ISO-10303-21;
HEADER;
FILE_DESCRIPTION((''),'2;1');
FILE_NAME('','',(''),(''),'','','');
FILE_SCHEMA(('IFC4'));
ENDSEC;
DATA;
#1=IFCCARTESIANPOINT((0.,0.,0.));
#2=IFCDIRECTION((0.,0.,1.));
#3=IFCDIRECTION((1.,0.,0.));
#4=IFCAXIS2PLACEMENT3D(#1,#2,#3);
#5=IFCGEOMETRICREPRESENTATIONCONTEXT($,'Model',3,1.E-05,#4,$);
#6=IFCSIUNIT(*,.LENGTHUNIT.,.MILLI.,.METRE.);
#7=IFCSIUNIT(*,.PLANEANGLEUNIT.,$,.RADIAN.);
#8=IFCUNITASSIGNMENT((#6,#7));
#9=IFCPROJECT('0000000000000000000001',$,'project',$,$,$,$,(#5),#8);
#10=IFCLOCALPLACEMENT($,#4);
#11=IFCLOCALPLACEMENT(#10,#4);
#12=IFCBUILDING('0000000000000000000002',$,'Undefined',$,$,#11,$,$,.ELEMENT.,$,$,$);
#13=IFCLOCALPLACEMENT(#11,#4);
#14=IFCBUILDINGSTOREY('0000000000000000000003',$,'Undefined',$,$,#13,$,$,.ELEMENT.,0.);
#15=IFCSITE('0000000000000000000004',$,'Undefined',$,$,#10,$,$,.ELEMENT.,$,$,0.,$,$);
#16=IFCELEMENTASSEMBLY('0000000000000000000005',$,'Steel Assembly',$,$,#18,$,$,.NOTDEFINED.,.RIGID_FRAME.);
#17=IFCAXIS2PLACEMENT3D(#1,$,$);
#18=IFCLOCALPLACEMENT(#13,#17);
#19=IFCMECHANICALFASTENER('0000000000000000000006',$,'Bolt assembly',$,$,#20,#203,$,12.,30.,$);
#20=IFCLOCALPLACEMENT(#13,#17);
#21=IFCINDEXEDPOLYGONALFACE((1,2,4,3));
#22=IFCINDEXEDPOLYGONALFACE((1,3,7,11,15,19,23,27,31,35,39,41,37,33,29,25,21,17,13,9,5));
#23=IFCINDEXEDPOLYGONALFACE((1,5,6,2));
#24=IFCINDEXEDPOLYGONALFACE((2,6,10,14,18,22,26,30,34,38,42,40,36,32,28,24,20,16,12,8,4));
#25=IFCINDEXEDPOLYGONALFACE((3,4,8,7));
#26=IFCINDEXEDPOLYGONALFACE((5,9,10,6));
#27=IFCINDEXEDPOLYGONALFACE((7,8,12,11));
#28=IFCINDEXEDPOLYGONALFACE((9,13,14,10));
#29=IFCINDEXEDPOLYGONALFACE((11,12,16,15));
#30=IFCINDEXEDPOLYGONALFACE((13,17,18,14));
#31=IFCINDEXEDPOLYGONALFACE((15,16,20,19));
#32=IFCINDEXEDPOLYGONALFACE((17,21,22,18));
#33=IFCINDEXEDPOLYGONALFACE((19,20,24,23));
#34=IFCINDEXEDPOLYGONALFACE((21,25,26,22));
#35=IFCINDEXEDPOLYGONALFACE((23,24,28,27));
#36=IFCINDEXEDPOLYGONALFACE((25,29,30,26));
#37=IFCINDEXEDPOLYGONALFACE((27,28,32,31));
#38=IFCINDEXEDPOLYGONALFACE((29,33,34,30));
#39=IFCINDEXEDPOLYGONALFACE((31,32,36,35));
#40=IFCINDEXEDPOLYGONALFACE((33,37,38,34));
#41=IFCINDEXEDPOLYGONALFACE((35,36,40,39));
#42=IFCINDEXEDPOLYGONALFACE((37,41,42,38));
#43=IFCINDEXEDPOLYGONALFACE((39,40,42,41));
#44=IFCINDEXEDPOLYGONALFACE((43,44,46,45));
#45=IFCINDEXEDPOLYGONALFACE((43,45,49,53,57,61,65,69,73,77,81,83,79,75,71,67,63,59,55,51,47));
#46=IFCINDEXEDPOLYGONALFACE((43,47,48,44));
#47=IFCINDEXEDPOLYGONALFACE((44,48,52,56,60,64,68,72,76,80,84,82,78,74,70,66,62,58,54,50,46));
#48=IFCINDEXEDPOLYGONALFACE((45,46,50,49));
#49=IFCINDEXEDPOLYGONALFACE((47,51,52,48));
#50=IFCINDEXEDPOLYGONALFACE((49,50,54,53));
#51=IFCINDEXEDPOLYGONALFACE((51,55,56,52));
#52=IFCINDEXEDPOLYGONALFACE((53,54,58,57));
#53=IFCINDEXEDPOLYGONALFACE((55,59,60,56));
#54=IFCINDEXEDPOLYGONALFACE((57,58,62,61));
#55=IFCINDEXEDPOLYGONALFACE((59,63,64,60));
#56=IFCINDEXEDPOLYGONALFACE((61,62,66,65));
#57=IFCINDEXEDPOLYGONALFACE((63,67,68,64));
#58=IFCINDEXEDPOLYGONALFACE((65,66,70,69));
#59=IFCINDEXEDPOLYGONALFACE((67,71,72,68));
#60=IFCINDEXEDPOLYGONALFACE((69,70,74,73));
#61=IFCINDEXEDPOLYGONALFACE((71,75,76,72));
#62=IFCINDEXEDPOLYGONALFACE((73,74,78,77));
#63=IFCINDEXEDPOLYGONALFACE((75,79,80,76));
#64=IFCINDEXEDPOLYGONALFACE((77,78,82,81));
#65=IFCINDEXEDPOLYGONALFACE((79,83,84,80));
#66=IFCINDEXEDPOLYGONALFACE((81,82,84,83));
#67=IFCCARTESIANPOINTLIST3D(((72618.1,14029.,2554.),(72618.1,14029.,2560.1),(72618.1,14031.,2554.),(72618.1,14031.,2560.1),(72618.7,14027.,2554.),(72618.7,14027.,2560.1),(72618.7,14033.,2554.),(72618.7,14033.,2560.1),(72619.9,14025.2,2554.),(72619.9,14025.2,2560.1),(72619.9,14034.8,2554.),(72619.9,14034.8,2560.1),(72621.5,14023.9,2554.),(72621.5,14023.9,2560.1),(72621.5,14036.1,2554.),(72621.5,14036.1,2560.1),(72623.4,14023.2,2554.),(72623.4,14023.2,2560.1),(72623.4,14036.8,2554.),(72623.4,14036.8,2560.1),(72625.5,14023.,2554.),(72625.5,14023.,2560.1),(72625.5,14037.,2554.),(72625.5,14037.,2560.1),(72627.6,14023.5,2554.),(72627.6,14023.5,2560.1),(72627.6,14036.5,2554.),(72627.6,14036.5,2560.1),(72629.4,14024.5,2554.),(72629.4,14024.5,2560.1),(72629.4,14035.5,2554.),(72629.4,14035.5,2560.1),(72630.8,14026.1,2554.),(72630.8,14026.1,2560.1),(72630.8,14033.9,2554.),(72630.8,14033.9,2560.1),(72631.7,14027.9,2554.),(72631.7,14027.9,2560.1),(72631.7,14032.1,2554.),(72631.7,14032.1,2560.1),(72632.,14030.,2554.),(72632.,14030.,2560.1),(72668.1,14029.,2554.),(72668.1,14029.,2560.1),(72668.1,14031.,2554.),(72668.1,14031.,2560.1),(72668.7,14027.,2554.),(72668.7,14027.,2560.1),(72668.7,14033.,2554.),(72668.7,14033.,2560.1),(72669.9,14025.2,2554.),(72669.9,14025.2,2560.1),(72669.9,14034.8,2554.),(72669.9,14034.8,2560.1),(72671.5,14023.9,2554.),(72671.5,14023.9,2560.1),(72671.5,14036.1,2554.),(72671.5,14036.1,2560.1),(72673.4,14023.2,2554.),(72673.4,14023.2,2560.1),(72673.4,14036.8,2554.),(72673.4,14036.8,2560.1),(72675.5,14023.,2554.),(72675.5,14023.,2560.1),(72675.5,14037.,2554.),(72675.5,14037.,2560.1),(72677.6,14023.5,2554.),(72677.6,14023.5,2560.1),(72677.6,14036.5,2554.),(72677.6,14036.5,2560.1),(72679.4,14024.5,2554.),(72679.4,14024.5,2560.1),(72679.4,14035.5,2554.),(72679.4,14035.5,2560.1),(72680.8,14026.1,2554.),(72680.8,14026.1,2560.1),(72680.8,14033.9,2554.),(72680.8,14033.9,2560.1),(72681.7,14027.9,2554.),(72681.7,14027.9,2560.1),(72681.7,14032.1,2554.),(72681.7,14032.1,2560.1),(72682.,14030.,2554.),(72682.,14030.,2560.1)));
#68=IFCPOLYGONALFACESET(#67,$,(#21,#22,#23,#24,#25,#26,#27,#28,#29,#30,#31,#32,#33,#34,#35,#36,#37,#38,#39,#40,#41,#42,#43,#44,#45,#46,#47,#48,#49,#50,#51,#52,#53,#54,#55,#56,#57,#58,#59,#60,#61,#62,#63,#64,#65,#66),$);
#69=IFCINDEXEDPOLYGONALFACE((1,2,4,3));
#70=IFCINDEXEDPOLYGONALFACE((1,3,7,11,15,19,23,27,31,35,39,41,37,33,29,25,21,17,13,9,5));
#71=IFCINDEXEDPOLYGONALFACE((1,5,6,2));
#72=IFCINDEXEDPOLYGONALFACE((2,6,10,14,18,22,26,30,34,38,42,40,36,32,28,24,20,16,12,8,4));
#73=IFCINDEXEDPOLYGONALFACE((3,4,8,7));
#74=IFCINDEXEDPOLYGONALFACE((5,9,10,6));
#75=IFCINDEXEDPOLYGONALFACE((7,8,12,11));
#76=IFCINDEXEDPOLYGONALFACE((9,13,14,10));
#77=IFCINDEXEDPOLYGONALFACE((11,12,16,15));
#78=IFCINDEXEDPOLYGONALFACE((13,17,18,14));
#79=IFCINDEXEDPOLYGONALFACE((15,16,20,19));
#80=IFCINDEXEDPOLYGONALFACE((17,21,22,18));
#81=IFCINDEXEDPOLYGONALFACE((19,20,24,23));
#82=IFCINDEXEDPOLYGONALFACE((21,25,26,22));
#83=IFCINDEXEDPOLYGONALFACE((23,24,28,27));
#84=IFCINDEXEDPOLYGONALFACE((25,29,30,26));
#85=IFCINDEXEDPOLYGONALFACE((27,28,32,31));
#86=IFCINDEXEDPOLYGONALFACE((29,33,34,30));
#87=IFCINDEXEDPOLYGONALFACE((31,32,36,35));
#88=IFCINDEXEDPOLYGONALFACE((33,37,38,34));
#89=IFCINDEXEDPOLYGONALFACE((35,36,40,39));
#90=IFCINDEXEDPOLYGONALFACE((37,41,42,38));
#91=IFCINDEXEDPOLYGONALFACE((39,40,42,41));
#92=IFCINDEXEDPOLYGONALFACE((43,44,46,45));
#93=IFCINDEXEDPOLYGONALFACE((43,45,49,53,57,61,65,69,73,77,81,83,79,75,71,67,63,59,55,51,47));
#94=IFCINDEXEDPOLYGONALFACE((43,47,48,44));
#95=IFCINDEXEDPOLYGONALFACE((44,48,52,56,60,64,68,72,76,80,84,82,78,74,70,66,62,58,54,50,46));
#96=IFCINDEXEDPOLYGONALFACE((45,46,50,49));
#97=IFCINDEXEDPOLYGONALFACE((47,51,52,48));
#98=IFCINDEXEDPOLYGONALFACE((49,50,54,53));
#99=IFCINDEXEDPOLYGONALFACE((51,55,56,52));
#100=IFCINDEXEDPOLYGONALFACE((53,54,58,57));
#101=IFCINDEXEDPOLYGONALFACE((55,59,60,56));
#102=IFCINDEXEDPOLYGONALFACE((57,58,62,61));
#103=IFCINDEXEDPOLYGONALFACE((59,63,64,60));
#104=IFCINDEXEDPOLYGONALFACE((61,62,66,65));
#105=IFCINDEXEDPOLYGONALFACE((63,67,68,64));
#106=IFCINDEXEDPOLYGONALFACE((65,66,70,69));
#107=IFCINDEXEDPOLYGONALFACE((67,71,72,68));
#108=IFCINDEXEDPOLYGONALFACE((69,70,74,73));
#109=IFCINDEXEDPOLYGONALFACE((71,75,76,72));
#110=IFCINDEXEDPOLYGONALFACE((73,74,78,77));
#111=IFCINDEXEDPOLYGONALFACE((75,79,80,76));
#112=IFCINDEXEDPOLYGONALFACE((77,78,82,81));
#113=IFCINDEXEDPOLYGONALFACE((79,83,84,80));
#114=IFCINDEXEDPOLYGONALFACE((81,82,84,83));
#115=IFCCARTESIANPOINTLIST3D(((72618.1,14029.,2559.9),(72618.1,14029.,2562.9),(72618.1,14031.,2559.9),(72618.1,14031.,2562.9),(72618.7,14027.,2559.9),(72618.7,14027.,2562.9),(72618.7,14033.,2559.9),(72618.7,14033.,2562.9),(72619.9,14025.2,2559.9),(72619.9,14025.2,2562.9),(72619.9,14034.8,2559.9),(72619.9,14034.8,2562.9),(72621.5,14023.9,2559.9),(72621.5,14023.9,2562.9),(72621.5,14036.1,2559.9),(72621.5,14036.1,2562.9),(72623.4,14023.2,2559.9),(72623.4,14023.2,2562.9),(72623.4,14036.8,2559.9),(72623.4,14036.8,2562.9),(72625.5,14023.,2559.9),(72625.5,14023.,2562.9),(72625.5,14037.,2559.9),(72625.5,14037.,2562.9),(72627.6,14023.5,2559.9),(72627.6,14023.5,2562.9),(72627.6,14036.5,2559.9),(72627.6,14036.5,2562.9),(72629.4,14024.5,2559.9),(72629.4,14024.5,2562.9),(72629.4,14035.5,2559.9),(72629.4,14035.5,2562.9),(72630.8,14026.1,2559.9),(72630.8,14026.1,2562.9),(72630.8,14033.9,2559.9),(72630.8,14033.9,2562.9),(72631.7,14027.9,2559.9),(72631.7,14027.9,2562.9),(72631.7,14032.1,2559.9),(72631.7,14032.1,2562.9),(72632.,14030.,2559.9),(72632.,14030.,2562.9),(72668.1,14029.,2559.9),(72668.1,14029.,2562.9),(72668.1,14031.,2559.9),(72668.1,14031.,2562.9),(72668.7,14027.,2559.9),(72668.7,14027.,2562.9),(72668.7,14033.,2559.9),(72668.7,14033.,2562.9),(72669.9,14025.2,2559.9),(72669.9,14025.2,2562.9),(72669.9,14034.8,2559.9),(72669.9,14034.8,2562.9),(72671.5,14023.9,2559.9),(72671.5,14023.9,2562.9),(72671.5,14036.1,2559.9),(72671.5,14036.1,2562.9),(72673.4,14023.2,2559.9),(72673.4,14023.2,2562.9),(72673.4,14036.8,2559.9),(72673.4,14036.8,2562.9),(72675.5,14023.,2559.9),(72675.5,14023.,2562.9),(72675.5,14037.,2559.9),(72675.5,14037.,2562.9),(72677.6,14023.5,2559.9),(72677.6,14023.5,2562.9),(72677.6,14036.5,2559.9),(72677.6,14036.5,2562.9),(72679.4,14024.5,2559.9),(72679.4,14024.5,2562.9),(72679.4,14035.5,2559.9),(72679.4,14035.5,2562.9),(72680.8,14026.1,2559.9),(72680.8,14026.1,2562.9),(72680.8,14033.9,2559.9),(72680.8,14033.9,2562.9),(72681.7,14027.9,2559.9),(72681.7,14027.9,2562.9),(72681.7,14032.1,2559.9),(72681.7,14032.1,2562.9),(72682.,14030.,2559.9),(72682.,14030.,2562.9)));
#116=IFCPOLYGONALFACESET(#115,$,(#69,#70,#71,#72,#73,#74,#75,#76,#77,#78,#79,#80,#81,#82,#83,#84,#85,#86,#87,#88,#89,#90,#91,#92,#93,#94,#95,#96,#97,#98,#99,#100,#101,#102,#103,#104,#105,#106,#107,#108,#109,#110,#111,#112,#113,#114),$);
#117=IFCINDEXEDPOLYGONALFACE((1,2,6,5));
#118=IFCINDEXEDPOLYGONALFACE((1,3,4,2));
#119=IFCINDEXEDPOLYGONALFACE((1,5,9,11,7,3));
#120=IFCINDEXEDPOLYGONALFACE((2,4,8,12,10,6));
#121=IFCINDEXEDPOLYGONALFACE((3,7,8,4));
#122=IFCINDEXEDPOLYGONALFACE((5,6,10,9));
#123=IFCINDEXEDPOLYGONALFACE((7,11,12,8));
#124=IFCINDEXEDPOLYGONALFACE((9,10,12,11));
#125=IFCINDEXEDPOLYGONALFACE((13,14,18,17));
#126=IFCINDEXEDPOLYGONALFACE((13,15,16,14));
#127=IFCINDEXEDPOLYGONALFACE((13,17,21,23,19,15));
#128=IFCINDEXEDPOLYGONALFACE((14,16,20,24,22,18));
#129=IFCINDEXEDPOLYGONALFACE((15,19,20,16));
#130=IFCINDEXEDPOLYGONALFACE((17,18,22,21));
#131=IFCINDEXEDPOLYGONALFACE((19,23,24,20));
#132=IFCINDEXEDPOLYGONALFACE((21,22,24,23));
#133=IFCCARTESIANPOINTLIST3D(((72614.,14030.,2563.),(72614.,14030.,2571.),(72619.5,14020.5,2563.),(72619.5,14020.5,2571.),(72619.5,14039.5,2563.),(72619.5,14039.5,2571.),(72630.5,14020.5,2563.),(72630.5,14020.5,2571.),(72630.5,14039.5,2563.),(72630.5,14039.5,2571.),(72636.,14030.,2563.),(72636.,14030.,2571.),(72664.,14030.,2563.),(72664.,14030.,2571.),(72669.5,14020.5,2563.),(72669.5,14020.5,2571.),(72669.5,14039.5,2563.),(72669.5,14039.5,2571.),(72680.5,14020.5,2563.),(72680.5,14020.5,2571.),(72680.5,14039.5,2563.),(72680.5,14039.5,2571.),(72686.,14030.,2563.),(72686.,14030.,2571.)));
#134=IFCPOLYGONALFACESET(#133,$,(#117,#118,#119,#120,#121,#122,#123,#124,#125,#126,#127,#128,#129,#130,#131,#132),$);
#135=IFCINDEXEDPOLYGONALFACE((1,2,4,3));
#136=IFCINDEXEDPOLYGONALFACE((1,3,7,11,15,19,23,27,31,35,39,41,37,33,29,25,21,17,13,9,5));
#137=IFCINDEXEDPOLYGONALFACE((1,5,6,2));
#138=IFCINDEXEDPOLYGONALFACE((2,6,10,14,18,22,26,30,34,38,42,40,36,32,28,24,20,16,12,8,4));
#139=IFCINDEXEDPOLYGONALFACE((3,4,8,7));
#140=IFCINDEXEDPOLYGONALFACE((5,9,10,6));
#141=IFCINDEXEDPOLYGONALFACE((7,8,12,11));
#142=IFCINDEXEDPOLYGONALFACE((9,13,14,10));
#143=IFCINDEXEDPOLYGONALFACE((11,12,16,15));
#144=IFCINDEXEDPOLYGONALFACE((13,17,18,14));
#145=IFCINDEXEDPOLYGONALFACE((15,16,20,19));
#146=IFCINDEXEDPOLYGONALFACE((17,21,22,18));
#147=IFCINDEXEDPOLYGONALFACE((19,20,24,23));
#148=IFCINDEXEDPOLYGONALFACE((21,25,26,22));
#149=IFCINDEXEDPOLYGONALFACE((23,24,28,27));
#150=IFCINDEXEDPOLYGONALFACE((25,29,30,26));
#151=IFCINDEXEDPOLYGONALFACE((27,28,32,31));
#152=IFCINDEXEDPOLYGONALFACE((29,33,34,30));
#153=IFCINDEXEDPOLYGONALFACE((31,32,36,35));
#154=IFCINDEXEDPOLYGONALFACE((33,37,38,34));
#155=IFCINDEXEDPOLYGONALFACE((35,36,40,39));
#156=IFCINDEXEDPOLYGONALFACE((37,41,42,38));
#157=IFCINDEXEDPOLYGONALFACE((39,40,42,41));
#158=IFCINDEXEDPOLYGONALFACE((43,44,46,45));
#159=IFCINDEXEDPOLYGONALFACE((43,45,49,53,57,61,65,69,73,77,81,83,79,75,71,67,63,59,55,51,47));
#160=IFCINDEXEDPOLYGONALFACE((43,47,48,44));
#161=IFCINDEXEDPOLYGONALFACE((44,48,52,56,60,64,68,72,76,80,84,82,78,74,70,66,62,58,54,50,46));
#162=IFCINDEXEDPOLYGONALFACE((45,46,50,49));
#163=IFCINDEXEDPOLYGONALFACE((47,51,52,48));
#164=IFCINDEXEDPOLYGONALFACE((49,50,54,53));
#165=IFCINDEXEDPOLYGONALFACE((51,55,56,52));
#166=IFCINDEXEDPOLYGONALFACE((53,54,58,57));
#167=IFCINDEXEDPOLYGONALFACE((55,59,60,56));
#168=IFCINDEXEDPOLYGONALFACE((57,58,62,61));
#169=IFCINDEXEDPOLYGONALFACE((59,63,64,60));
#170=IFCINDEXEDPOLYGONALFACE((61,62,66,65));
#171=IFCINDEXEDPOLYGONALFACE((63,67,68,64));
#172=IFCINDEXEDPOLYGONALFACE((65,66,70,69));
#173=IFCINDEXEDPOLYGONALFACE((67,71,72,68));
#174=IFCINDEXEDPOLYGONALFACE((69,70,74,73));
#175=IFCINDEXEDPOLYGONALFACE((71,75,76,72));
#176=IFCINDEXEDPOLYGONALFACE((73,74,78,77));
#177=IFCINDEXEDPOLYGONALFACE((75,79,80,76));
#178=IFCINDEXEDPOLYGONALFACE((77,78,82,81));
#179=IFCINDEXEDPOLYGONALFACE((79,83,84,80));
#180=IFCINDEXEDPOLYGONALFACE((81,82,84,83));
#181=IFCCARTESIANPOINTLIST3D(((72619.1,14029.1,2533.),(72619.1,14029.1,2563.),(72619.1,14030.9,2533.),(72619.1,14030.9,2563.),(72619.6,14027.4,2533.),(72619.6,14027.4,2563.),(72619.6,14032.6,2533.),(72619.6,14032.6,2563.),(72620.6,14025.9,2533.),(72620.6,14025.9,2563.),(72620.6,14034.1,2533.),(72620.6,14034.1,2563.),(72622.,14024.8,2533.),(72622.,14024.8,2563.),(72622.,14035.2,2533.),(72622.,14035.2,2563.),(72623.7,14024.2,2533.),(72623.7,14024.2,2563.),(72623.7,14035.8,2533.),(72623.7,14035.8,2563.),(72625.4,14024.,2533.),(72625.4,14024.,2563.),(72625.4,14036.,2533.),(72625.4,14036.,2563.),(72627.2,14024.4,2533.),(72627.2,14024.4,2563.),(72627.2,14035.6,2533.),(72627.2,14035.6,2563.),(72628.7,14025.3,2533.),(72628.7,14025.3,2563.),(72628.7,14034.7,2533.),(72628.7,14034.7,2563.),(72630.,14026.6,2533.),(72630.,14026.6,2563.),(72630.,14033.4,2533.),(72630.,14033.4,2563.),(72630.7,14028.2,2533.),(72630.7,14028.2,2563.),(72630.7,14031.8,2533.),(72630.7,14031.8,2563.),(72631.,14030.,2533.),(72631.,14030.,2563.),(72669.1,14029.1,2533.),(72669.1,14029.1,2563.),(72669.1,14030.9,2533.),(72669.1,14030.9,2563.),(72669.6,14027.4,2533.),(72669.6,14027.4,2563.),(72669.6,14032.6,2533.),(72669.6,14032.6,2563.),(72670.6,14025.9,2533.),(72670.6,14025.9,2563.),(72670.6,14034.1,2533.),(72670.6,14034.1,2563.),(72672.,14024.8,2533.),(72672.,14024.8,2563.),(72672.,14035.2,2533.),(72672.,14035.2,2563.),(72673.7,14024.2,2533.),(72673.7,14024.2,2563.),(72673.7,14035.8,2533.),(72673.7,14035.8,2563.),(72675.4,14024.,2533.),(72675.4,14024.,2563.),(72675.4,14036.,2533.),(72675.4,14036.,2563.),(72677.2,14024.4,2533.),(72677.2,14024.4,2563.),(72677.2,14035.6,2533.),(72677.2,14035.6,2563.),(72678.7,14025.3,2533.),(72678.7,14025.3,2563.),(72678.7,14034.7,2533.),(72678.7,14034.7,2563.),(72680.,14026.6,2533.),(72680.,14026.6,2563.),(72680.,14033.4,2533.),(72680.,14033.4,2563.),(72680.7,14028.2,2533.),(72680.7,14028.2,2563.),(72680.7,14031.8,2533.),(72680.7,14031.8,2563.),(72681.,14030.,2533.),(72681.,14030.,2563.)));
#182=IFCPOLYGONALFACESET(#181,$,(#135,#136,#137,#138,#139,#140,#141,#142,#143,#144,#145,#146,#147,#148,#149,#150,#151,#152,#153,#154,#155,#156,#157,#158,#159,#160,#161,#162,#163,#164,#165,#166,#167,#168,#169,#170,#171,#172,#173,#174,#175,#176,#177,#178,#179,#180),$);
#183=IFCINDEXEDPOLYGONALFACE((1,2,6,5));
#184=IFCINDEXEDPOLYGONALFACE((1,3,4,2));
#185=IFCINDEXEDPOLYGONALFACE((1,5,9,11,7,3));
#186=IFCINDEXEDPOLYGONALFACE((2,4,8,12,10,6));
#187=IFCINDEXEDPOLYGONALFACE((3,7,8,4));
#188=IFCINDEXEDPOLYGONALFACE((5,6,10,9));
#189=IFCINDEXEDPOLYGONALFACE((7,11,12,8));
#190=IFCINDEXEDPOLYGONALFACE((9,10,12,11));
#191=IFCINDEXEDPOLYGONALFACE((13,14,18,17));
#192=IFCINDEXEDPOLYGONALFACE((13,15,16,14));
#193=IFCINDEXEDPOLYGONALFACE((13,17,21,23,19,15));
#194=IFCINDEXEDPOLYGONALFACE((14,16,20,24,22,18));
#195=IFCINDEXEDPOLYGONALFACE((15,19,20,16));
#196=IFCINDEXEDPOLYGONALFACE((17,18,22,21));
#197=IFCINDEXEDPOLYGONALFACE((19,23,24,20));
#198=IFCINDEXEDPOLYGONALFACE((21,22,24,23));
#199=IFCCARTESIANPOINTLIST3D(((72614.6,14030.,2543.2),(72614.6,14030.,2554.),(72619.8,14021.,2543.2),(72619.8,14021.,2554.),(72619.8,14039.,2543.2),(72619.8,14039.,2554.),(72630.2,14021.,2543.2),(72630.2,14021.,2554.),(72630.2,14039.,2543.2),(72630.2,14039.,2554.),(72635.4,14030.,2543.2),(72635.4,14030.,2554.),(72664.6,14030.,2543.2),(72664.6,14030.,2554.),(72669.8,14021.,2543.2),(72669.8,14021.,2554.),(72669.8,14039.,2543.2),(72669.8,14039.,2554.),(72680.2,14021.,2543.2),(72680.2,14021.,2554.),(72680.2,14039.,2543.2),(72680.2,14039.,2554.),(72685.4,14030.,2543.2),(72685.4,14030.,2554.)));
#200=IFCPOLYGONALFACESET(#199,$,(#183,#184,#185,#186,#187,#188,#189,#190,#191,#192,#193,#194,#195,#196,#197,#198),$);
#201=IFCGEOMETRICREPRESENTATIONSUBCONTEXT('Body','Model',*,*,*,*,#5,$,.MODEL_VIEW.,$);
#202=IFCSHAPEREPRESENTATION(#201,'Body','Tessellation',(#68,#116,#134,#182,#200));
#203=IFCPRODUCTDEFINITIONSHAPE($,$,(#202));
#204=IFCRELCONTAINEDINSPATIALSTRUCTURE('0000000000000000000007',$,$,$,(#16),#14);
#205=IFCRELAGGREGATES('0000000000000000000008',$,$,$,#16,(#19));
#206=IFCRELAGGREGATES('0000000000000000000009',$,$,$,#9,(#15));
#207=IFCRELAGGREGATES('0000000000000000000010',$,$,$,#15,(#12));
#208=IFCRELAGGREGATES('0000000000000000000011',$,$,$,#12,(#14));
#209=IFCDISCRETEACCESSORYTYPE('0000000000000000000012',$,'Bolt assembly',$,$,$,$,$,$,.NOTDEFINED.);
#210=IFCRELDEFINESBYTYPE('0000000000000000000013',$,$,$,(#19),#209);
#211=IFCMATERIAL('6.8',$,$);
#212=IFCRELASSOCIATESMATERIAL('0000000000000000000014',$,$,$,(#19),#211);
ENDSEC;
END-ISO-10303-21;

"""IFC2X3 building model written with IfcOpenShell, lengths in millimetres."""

from ifc_helpers import new_model, si_unit, frame, origin_with_axes, origin_2d_with_axis, place, context, subcontext, project, spatial, polyline, circle, outline, extrude, source, transform, mapped, material, type_object, element, aggregate, save


model = new_model("IFC2X3")

# Units and contexts
model_context = context("Model", 3, precision=1e-05, world=origin_with_axes())
body_context = subcontext(model_context, "Body", "Model", "MODEL_VIEW")
ifc_project = project(units=[si_unit("LENGTHUNIT", "METRE", prefix="MILLI"), si_unit("PLANEANGLEUNIT", "RADIAN")], contexts=[model_context])

# Site, building, storey
site_placement = place(None, origin_with_axes())
site = spatial("IfcSite", under=ifc_project, at=site_placement, Name="Undefined", CompositionType="ELEMENT", RefElevation=0.0)
building_placement = place(site_placement, origin_with_axes())
building = spatial("IfcBuilding", under=site, at=building_placement, Name="Undefined", CompositionType="ELEMENT")
storey_placement = place(building_placement, origin_with_axes())
storey = spatial("IfcBuildingStorey", under=building, at=storey_placement, Name="Undefined", CompositionType="ELEMENT", Elevation=0.0)

# Element assembly
assembly_1_placement = place(storey_placement, origin_with_axes())
assembly_1 = element("IfcElementAssembly", 1, at=assembly_1_placement, inside=storey, Name="Steel Assembly", AssemblyPlace="NOTDEFINED", PredefinedType="RIGID_FRAME")

# Shared definitions
ifc_material_1 = material(Name="6.8")
discrete_accessory_type_1 = type_object("IfcDiscreteAccessoryType", Name="Bolt assembly")

# Mechanical fastener
shared_shape_1 = source(origin_with_axes(), body_context, "Body", "SweptSolid", [
    extrude(circle(Radius=7.0, at=origin_2d_with_axis()), frame((0.0, -6.1, 0.0), z_axis=(0.0, 1.0, 0.0), x_axis=(1.0, 0.0, 0.0)), (0.0, 0.0, 1.0), 6.1),
    extrude(circle(Radius=7.0, at=origin_2d_with_axis()), frame((0.0, -8.9, 0.0), z_axis=(0.0, 1.0, 0.0), x_axis=(1.0, 0.0, 0.0)), (0.0, 0.0, 1.0), 3.0),
    extrude(outline(polyline([(11.0, 0.0), (5.5, 9.5), (-5.5, 9.5), (-11.0, 0.0), (-5.5, -9.5), (5.5, -9.5), (11.0, 0.0)])), frame((0.0, -17.0, 0.0), z_axis=(0.0, 1.0, 0.0), x_axis=(1.0, 0.0, 0.0)), (0.0, 0.0, 1.0), 8.0),
    extrude(circle(Radius=6.0, at=origin_2d_with_axis()), frame((0.0, -9.0, 0.0), z_axis=(0.0, 1.0, 0.0), x_axis=(1.0, 0.0, 0.0)), (0.0, 0.0, 1.0), 30.0),
    extrude(outline(polyline([(10.4, 0.0), (5.2, 9.0), (-5.2, 9.0), (-10.4, 0.0), (-5.2, -9.0), (5.2, -9.0), (10.4, 0.0)])), frame((0.0, 0.0, 0.0), z_axis=(0.0, 1.0, 0.0), x_axis=(1.0, 0.0, 0.0)), (0.0, 0.0, 1.0), 10.8),
])
mechanical_fastener_1_placement = place(assembly_1_placement, frame((72625.0, 14030.0, 2554.0), z_axis=(0.0, 1.0, 0.0), x_axis=(1.0, 0.0, 0.0)))
mechanical_fastener_1 = element("IfcMechanicalFastener", 2, at=mechanical_fastener_1_placement, type_object=discrete_accessory_type_1, material=ifc_material_1, Name="Bolt assembly", NominalDiameter=12.0, NominalLength=30.0, context=body_context, shape_type="MappedRepresentation", body=[
    mapped(shared_shape_1, transform((0.0, 0.0, 0.0))),
    mapped(shared_shape_1, transform((50.0, 0.0, 0.0))),
])
aggregate(assembly_1, [mechanical_fastener_1])

save(model, "model.ifc")
